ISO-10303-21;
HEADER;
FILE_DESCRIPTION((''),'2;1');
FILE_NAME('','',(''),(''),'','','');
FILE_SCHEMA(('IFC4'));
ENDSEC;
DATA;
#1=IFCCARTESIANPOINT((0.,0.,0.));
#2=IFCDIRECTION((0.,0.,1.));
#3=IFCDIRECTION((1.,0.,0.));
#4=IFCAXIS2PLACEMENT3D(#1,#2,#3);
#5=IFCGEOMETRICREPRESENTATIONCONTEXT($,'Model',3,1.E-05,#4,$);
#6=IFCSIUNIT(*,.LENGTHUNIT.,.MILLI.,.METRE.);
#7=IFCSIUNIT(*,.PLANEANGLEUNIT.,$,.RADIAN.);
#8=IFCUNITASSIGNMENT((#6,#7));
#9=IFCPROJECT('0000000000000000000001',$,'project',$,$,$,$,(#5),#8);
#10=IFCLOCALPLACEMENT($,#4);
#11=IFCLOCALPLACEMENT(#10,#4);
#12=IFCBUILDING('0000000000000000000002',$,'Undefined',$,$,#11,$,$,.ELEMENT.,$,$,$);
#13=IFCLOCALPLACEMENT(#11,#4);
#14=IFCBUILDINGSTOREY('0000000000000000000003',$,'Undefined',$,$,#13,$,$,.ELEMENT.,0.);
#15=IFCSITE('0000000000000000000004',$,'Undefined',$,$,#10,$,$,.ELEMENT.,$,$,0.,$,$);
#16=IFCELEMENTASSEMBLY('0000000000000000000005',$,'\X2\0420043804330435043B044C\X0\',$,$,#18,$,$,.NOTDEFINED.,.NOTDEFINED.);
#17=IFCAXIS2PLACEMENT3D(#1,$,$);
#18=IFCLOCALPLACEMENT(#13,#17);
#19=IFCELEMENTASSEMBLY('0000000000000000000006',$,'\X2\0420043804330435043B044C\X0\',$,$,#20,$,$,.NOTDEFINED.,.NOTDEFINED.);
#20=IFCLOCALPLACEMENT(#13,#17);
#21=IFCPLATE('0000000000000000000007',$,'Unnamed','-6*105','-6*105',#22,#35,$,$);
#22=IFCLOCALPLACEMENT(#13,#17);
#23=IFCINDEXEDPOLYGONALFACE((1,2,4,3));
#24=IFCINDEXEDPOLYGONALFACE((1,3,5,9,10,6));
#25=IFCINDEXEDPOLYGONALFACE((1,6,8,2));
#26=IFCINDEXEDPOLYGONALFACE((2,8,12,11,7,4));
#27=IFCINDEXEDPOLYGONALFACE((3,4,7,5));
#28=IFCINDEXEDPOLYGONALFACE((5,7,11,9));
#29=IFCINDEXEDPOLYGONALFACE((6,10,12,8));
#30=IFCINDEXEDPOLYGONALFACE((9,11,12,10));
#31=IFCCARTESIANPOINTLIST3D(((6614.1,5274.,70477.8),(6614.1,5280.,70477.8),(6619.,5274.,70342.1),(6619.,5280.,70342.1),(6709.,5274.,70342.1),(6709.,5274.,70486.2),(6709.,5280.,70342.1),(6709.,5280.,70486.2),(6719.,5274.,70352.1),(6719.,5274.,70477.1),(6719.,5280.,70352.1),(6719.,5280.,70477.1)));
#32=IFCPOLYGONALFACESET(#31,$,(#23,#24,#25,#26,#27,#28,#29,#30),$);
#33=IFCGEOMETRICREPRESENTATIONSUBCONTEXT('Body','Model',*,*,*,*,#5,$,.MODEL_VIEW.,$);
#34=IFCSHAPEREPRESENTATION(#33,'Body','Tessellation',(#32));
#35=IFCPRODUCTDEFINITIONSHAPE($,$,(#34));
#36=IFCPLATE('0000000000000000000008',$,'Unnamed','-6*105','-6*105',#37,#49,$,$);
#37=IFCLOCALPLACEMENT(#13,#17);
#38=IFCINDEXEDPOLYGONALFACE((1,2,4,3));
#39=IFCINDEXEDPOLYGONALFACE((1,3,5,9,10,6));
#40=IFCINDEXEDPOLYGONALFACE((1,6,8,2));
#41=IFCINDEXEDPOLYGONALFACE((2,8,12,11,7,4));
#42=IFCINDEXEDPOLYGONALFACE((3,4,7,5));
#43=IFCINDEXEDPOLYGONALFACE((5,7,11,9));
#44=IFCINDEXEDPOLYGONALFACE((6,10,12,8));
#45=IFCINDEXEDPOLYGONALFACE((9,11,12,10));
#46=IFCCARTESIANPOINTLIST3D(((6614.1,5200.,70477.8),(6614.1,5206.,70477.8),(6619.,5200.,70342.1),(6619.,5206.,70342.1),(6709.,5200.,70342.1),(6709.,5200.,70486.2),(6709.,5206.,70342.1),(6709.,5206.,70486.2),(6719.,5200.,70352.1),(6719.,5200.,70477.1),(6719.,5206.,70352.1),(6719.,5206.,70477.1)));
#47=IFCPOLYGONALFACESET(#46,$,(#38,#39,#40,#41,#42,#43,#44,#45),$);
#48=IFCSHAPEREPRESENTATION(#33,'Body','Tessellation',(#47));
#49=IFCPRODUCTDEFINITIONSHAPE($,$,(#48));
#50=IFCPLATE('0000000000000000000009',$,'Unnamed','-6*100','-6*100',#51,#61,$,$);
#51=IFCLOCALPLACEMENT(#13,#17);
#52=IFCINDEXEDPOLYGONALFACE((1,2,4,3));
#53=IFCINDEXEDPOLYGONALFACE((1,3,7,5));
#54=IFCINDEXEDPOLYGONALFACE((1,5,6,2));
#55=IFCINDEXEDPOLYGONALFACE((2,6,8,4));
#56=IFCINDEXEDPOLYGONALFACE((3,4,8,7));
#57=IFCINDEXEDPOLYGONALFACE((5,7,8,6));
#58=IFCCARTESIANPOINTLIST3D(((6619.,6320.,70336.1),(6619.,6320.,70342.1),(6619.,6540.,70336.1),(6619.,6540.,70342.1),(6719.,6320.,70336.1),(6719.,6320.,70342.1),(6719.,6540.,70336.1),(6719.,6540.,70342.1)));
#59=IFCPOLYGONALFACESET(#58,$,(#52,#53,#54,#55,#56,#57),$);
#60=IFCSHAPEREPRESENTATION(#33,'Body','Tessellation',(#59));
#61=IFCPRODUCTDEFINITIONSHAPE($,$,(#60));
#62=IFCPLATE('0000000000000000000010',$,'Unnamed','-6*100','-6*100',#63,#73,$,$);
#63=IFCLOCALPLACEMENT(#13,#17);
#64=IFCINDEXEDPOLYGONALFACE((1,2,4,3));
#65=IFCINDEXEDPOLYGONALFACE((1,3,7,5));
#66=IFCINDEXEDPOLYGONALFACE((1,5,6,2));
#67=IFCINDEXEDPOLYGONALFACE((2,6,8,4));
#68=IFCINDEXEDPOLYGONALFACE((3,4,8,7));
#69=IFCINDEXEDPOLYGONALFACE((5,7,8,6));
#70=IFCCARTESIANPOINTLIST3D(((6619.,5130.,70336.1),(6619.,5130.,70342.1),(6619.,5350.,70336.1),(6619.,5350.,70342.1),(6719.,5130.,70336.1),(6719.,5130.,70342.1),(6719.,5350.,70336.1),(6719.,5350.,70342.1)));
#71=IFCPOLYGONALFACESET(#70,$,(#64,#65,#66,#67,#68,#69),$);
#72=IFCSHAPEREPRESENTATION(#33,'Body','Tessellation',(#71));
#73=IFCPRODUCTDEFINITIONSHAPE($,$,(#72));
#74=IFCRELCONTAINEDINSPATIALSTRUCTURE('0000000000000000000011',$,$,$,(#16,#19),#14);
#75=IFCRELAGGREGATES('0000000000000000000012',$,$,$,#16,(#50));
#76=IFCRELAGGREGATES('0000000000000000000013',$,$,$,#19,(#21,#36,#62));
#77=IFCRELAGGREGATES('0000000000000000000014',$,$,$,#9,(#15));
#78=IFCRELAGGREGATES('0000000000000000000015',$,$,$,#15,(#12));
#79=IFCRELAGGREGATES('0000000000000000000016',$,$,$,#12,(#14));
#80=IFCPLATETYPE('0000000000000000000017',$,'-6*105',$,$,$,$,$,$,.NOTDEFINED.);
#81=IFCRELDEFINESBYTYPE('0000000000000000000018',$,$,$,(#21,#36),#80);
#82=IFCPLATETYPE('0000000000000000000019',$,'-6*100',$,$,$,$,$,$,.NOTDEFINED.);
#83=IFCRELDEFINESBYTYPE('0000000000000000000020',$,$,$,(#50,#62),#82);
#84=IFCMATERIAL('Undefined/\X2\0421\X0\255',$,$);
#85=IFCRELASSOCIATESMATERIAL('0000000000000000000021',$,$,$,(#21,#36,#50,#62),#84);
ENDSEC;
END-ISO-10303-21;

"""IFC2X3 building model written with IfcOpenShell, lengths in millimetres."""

from ifc_helpers import new_model, si_unit, frame, origin_with_axes, place, context, subcontext, project, spatial, polyline, outline, extrude, material, type_object, element, aggregate, save


model = new_model("IFC2X3")

# Units and contexts
model_context = context("Model", 3, precision=1e-05, world=origin_with_axes())
body_context = subcontext(model_context, "Body", "Model", "MODEL_VIEW")
ifc_project = project(units=[si_unit("LENGTHUNIT", "METRE", prefix="MILLI"), si_unit("PLANEANGLEUNIT", "RADIAN")], contexts=[model_context])

# Site, building, storey
site_placement = place(None, origin_with_axes())
site = spatial("IfcSite", under=ifc_project, at=site_placement, Name="Undefined", CompositionType="ELEMENT", RefElevation=0.0)
building_placement = place(site_placement, origin_with_axes())
building = spatial("IfcBuilding", under=site, at=building_placement, Name="Undefined", CompositionType="ELEMENT")
storey_placement = place(building_placement, origin_with_axes())
storey = spatial("IfcBuildingStorey", under=building, at=storey_placement, Name="Undefined", CompositionType="ELEMENT", Elevation=0.0)

# Element assemblies
assembly_1_placement = place(storey_placement, origin_with_axes())
assembly_1 = element("IfcElementAssembly", 1, at=assembly_1_placement, inside=storey, Name="Ригель", AssemblyPlace="NOTDEFINED", PredefinedType="NOTDEFINED")
ifc_material_1 = material(Name="Undefined/С255")
assembly_2_placement = place(storey_placement, origin_with_axes())
assembly_2 = element("IfcElementAssembly", 2, at=assembly_2_placement, inside=storey, Name="Ригель", AssemblyPlace="NOTDEFINED", PredefinedType="NOTDEFINED")

# Plates
plate_type_1 = type_object("IfcPlateType", Name="-6*105", PredefinedType="NOTDEFINED")
plate_1_placement = place(assembly_2_placement, frame((6719.0, 5277.0, 70342.1), z_axis=(0.0, -1.0, 0.0), x_axis=(0.0, 0.0, 1.0)))
plate_1 = element("IfcPlate", 3, at=plate_1_placement, type_object=plate_type_1, material=ifc_material_1, Name="Unnamed", Description="-6*105", ObjectType="-6*105", context=body_context, shape_type="SweptSolid", body=[
    extrude(outline(polyline([(0.0, 10.0), (10.0, 0.0), (135.0, 0.0), (144.1, 10.0), (135.7, 104.9), (0.0, 100.0), (0.0, 10.0)])), frame((0.0, 0.0, -3.0), z_axis=(0.0, 0.0, 1.0), x_axis=(1.0, 0.0, 0.0)), (0.0, 0.0, 1.0), 6.0),
])
plate_2_placement = place(assembly_2_placement, frame((6719.0, 5203.0, 70342.1), z_axis=(0.0, -1.0, 0.0), x_axis=(0.0, 0.0, 1.0)))
plate_2 = element("IfcPlate", 4, at=plate_2_placement, type_object=plate_type_1, material=ifc_material_1, Name="Unnamed", Description="-6*105", ObjectType="-6*105", context=body_context, shape_type="SweptSolid", body=[
    extrude(outline(polyline([(0.0, 10.0), (10.0, 0.0), (135.0, 0.0), (144.1, 10.0), (135.7, 104.9), (0.0, 100.0), (0.0, 10.0)])), frame((0.0, 0.0, -3.0), z_axis=(0.0, 0.0, 1.0), x_axis=(1.0, 0.0, 0.0)), (0.0, 0.0, 1.0), 6.0),
])
plate_type_2 = type_object("IfcPlateType", Name="-6*100", PredefinedType="NOTDEFINED")
plate_3_placement = place(assembly_1_placement, frame((6719.0, 6540.0, 70339.1), z_axis=(0.0, 0.0, 1.0), x_axis=(-1.0, 0.0, 0.0)))
plate_3 = element("IfcPlate", 5, at=plate_3_placement, type_object=plate_type_2, material=ifc_material_1, Name="Unnamed", Description="-6*100", ObjectType="-6*100", context=body_context, shape_type="SweptSolid", body=[
    extrude(outline(polyline([(0.0, 0.0), (100.0, 0.0), (100.0, 220.0), (0.0, 220.0), (0.0, 0.0)])), frame((0.0, 0.0, -3.0), z_axis=(0.0, 0.0, 1.0), x_axis=(1.0, 0.0, 0.0)), (0.0, 0.0, 1.0), 6.0),
])
plate_4_placement = place(assembly_2_placement, frame((6719.0, 5350.0, 70339.1), z_axis=(0.0, 0.0, 1.0), x_axis=(-1.0, 0.0, 0.0)))
plate_4 = element("IfcPlate", 6, at=plate_4_placement, type_object=plate_type_2, material=ifc_material_1, Name="Unnamed", Description="-6*100", ObjectType="-6*100", context=body_context, shape_type="SweptSolid", body=[
    extrude(outline(polyline([(0.0, 0.0), (100.0, 0.0), (100.0, 220.0), (0.0, 220.0), (0.0, 0.0)])), frame((0.0, 0.0, -3.0), z_axis=(0.0, 0.0, 1.0), x_axis=(1.0, 0.0, 0.0)), (0.0, 0.0, 1.0), 6.0),
])

aggregate(assembly_1, [plate_3])
aggregate(assembly_2, [plate_1, plate_2, plate_4])

save(model, "model.ifc")
